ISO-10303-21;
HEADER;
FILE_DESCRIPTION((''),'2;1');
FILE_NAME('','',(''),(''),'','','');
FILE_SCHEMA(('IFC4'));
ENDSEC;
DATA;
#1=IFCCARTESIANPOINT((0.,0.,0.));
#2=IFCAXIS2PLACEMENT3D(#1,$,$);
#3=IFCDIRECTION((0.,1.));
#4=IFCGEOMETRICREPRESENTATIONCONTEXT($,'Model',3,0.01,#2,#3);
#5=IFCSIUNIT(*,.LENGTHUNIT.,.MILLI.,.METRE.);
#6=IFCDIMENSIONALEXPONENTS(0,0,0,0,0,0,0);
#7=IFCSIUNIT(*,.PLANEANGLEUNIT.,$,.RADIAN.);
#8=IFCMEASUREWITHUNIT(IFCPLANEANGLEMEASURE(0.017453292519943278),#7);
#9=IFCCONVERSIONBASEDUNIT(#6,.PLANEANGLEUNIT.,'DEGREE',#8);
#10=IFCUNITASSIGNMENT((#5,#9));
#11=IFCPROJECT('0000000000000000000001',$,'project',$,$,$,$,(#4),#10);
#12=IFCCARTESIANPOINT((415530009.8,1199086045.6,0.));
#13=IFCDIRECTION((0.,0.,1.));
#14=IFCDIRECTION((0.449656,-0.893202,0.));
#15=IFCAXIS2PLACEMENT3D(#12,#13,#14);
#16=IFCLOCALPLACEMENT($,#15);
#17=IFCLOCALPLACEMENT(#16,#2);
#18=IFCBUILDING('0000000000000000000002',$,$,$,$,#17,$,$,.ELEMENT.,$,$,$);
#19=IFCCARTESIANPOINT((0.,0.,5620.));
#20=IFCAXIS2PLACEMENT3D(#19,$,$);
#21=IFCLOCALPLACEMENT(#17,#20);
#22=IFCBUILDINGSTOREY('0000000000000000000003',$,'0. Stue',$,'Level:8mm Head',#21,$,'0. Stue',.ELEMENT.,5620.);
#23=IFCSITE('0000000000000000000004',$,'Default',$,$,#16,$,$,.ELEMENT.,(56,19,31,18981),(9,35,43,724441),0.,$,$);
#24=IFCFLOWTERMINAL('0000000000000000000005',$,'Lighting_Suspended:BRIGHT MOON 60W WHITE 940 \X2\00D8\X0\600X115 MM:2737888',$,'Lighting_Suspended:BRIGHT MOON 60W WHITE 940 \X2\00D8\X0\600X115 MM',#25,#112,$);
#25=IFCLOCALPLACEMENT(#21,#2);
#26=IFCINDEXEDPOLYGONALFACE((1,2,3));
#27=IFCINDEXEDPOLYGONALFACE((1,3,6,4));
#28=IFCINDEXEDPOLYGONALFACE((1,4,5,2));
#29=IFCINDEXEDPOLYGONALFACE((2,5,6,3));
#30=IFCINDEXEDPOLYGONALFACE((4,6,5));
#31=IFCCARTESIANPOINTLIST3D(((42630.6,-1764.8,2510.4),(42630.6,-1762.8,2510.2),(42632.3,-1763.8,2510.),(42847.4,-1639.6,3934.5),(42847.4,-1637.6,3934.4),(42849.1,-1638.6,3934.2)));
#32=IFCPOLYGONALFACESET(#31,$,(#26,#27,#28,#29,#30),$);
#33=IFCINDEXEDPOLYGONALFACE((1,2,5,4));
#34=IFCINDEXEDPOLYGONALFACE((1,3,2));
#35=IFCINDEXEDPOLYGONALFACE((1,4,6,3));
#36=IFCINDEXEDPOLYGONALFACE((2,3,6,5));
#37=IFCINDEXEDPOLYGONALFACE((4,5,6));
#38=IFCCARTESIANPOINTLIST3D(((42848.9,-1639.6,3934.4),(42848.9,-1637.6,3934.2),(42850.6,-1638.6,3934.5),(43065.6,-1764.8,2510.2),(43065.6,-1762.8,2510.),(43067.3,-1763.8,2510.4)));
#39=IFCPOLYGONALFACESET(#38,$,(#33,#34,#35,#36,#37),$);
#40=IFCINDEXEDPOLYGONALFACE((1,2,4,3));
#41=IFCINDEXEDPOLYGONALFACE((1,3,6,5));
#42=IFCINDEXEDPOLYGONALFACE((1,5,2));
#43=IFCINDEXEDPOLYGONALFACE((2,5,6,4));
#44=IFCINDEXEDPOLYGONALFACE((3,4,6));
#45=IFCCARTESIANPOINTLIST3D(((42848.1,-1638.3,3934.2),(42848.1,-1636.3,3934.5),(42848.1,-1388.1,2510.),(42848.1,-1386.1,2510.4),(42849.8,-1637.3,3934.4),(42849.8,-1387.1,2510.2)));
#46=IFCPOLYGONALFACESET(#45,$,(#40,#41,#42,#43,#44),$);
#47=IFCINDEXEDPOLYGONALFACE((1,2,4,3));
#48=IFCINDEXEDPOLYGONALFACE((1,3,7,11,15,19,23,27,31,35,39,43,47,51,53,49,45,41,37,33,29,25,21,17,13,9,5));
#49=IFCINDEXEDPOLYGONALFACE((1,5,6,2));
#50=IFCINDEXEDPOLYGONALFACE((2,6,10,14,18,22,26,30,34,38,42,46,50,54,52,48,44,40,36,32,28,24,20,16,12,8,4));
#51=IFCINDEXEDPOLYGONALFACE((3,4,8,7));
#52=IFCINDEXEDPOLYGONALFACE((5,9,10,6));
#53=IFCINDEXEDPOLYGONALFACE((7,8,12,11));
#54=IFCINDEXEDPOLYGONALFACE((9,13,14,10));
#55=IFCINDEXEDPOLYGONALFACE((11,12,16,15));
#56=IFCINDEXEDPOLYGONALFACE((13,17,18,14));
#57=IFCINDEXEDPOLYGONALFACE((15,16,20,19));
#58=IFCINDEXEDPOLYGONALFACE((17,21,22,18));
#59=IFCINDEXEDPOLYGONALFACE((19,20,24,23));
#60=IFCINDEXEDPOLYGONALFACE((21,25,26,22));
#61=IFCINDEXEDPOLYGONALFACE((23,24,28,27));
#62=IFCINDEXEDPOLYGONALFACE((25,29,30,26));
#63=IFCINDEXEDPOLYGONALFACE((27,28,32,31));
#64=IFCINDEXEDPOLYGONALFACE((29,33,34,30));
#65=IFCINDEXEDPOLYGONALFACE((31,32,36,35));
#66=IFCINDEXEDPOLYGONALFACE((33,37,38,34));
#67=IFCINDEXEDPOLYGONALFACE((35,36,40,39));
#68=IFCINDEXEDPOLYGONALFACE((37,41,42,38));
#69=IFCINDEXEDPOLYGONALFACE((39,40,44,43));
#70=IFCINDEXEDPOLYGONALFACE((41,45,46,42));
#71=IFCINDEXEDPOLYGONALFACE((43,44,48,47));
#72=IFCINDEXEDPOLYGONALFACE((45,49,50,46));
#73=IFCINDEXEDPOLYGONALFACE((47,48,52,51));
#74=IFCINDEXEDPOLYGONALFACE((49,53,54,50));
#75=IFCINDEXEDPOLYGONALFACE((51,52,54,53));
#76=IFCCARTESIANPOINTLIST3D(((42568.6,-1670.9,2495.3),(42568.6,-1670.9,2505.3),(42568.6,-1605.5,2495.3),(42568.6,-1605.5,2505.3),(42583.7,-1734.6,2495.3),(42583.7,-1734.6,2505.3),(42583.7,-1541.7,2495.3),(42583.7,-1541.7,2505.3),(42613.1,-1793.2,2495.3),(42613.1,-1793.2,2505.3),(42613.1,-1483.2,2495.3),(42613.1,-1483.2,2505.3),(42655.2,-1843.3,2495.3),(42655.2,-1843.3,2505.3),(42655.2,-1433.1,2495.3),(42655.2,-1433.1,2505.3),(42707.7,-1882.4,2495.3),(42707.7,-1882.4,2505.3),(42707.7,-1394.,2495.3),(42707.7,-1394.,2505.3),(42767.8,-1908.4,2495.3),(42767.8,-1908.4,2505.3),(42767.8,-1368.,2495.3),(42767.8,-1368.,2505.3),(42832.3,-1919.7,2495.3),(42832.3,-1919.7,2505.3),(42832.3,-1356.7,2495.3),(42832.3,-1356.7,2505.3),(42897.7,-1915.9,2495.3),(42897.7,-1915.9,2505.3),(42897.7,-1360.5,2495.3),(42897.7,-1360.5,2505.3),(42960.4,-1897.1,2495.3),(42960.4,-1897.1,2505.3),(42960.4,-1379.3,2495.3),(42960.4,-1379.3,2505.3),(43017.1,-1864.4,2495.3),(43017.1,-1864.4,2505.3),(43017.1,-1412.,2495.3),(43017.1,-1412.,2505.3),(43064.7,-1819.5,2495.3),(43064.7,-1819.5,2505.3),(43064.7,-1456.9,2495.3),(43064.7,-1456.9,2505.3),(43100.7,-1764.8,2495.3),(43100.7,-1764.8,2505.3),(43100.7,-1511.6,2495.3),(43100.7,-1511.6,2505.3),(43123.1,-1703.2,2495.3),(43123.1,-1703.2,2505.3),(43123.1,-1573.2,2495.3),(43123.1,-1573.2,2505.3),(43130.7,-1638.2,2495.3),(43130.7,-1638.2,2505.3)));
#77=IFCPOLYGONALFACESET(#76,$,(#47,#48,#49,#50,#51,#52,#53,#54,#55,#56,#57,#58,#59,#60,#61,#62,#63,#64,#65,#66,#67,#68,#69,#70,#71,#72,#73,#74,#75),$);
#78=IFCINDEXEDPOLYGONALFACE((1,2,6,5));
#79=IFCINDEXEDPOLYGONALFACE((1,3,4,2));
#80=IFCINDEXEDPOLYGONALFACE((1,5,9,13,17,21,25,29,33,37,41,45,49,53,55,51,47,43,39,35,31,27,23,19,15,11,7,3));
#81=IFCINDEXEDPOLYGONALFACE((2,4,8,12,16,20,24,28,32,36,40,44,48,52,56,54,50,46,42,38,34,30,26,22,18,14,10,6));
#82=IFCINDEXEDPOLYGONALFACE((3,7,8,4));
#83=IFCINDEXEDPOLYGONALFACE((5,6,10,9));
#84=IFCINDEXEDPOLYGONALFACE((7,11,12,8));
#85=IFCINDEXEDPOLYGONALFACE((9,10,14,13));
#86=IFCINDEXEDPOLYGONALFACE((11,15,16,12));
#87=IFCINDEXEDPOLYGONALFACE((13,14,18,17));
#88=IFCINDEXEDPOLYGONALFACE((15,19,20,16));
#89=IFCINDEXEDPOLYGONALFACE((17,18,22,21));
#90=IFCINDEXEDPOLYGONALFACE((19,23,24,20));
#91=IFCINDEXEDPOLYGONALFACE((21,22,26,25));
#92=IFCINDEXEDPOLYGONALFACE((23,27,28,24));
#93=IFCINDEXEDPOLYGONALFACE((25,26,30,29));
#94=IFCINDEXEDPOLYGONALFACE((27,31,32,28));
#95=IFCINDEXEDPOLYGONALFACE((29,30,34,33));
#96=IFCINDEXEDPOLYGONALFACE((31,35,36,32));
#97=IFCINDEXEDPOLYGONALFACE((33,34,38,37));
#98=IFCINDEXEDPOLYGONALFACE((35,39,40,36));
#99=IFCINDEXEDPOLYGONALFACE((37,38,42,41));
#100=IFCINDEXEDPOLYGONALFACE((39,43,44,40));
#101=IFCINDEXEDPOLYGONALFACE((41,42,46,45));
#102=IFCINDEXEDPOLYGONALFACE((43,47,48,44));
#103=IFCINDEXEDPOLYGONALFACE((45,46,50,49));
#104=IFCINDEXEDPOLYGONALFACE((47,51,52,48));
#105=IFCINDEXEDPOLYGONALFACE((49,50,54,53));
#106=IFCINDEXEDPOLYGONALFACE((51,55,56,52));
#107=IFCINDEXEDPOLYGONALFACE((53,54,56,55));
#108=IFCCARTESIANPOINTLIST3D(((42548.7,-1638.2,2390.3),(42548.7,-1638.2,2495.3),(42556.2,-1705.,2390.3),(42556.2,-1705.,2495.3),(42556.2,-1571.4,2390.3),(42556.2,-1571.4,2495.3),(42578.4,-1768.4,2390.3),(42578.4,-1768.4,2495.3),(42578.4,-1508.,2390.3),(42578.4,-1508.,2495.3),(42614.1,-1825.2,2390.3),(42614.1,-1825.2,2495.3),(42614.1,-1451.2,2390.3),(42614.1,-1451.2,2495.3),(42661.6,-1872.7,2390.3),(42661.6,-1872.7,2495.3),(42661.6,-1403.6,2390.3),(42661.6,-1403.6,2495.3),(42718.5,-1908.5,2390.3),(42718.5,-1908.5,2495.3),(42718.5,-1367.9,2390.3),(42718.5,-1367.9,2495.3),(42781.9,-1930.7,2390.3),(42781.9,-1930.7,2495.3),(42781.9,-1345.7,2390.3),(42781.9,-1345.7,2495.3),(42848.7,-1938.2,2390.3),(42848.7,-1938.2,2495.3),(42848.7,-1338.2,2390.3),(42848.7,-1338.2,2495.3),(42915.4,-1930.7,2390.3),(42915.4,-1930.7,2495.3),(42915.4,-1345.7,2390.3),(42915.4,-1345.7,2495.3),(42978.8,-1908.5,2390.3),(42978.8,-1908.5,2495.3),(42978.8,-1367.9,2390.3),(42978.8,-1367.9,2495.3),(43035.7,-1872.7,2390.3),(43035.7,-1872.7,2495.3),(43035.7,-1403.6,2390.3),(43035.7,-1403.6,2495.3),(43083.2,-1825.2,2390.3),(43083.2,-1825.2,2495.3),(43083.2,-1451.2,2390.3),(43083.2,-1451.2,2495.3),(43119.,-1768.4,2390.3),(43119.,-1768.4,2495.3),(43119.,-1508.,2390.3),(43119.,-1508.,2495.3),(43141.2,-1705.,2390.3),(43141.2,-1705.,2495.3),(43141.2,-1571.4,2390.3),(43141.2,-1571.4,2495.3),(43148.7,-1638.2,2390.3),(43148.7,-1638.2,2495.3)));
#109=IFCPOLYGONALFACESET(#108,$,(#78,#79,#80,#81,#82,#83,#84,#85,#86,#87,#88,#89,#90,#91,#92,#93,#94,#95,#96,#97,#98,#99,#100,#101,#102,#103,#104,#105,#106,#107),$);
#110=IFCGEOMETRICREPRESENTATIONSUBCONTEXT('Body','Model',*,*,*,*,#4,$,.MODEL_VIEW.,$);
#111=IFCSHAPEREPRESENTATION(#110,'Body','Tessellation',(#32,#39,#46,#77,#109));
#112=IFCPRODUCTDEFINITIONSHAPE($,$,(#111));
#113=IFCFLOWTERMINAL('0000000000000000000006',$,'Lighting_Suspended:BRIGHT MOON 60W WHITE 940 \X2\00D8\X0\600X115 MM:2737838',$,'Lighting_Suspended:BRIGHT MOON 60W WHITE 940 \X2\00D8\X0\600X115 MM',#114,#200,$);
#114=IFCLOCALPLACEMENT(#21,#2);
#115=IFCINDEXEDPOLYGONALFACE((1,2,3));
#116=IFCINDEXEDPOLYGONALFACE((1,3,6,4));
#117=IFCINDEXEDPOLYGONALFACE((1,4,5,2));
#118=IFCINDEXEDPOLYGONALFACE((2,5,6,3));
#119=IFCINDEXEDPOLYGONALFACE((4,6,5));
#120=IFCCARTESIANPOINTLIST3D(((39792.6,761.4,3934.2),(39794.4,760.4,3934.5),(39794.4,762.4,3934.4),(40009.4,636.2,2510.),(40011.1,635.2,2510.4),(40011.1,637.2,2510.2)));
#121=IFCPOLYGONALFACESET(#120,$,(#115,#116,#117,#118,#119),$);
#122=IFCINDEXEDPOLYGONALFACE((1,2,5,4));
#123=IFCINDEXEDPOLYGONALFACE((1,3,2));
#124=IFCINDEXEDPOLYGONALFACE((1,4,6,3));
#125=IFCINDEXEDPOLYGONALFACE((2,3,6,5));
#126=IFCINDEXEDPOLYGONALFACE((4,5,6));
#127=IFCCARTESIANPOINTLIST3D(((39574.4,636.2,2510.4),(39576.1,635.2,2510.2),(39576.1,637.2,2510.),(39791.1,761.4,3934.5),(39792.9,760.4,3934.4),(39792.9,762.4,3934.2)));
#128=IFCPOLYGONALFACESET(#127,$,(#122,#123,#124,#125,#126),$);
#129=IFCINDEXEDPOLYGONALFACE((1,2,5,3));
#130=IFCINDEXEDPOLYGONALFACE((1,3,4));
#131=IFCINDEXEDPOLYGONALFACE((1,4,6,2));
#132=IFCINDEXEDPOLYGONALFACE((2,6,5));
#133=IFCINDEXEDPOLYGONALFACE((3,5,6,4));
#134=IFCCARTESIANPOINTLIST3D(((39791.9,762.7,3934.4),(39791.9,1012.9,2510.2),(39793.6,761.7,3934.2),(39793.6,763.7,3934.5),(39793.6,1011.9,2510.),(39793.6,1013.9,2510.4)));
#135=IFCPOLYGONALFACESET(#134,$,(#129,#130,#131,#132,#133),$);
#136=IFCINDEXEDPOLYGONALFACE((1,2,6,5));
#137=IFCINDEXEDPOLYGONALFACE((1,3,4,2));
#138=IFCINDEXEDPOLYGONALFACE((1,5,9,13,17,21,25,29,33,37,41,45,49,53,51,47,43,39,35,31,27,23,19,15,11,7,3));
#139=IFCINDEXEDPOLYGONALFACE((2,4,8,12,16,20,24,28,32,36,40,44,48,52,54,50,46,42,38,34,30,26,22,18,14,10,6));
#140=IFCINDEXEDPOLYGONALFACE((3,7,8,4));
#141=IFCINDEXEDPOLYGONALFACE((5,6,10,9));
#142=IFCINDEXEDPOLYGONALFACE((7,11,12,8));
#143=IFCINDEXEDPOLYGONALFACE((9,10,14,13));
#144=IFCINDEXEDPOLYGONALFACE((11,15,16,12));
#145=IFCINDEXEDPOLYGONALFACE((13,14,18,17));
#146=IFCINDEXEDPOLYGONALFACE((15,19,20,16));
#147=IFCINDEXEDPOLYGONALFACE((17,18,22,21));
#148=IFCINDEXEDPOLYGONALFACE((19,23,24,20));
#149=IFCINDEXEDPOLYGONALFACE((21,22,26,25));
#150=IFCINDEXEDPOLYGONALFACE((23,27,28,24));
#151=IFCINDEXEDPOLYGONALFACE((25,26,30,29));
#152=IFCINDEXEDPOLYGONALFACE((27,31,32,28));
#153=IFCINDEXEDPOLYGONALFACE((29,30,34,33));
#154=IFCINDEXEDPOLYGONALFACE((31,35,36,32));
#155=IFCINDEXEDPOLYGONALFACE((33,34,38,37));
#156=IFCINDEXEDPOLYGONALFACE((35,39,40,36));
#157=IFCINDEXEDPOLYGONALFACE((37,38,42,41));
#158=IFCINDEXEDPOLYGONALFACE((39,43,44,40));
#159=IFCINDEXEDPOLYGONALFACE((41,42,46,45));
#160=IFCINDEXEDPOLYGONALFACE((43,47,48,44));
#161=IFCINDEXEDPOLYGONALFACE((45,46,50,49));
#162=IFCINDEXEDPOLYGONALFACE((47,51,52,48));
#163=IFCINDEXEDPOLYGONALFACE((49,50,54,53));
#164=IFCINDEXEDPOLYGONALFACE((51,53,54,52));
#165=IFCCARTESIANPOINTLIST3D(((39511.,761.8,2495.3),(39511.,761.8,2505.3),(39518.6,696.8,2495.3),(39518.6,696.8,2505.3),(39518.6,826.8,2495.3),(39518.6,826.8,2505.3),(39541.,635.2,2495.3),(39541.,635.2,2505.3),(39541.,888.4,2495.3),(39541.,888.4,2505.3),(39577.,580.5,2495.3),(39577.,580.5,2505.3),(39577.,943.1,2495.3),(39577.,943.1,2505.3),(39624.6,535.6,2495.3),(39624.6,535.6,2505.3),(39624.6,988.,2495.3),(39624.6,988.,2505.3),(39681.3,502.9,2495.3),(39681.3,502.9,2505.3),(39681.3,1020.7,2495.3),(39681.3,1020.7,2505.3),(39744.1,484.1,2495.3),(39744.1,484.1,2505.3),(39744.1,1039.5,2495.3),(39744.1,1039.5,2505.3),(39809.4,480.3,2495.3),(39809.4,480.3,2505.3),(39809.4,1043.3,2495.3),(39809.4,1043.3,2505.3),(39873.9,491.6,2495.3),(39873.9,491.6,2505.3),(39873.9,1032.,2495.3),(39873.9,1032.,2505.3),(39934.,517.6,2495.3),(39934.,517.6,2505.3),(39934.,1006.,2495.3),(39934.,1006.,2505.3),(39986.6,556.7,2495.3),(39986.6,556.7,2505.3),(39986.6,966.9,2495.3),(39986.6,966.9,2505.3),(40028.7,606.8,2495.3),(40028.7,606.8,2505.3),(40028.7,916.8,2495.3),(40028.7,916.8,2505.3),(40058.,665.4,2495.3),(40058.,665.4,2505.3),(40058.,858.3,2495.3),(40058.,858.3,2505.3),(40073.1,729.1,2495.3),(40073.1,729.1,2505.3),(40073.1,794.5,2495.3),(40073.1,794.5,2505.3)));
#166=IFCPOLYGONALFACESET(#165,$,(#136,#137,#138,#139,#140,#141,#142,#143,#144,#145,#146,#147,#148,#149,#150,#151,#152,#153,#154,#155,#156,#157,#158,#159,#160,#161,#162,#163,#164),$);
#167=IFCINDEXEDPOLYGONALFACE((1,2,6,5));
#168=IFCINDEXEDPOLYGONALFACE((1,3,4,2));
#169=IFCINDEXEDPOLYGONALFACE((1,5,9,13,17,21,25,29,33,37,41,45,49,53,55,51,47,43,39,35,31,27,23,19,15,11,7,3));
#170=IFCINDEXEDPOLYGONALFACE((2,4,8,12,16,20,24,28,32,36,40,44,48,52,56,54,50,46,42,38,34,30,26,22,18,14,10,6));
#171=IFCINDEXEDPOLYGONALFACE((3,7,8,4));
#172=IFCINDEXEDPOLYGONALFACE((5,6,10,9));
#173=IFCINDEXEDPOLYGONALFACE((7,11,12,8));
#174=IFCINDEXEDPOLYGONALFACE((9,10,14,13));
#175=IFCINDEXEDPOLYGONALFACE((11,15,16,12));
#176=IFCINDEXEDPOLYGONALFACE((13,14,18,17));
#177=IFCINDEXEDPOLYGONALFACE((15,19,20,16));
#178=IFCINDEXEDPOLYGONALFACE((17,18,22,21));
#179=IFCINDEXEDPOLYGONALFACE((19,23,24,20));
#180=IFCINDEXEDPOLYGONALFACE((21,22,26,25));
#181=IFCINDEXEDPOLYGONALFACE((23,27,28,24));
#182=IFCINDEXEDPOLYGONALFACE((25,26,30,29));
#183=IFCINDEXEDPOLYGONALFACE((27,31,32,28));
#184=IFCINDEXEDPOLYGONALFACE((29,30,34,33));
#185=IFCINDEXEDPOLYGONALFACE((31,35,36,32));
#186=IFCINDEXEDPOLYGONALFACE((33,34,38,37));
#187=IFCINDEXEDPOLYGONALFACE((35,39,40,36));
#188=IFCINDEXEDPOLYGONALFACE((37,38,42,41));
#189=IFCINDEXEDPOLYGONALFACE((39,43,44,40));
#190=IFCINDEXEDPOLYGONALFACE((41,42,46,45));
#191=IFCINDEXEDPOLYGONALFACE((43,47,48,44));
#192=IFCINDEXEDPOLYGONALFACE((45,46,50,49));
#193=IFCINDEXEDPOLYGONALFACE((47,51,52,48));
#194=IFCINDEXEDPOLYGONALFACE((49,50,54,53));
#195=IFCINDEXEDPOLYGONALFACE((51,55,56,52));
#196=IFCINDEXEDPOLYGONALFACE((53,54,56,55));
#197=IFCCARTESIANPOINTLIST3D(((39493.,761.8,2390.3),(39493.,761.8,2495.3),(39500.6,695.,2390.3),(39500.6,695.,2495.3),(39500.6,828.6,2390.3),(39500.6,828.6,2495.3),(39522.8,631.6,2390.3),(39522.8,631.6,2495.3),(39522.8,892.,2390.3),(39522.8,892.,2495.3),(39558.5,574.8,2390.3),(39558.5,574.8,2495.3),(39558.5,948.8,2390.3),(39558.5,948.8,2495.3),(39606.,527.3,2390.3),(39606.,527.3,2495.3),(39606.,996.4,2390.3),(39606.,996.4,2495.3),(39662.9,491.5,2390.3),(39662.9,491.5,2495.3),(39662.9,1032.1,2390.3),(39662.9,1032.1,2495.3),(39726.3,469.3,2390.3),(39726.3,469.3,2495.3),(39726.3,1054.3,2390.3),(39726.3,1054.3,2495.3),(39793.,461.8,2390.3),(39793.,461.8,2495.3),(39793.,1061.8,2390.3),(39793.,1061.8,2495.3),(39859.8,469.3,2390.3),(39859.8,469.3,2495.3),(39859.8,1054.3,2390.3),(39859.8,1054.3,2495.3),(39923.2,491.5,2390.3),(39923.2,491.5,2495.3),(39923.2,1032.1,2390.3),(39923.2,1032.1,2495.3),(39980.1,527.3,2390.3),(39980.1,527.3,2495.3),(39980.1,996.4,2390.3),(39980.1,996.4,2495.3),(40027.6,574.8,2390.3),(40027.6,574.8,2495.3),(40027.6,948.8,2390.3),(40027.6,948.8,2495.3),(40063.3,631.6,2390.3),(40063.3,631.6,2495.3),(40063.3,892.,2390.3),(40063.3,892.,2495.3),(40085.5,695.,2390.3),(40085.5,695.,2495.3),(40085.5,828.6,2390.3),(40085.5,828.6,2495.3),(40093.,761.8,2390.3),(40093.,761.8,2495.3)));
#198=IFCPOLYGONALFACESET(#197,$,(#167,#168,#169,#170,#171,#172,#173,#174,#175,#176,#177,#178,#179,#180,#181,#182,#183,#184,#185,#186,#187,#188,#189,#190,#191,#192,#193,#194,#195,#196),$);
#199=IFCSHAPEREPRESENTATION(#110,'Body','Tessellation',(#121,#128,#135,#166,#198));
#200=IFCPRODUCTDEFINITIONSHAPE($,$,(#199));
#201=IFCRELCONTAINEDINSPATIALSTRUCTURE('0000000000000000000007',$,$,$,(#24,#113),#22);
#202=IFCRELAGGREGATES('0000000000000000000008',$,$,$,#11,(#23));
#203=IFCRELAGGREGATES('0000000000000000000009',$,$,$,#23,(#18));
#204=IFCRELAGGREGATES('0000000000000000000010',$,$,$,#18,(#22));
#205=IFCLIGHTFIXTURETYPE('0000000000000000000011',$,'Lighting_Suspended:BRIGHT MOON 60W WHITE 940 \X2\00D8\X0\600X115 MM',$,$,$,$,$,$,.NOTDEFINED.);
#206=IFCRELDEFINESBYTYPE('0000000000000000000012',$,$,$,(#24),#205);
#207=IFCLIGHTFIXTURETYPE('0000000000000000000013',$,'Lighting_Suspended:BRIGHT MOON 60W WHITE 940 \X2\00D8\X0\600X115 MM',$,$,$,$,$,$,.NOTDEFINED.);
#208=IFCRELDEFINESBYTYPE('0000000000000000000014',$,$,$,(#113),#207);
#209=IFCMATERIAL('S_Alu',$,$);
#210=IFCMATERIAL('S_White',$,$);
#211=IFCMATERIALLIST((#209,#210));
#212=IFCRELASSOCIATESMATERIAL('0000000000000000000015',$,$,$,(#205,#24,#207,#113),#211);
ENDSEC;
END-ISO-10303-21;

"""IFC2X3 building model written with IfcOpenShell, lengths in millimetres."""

from ifc_helpers import new_model, entity, si_unit, converted_unit, direction, frame, frame_2d, origin, place, context, subcontext, project, spatial, polyline, circle, outline, extrude, source, transform, mapped, material, material_list, type_object, type_shapes, element, save


model = new_model("IFC2X3")

# Units and contexts
model_context = context("Model", 3, precision=0.01, world=origin(), true_north=direction((0.0, 1.0)))
body_context = subcontext(model_context, "Body", "Model", "MODEL_VIEW")
ifc_project = project(units=[si_unit("LENGTHUNIT", "METRE", prefix="MILLI"), converted_unit("PLANEANGLEUNIT", "DEGREE", entity("IfcPlaneAngleMeasure", 0.017453292519943278), si_unit("PLANEANGLEUNIT", "RADIAN"), dimensions=[0, 0, 0, 0, 0, 0, 0])], contexts=[model_context])

# Site, building, storey
site_placement = place(None, frame((415530009.8, 1199086045.6, 0.0), z_axis=(0.0, 0.0, 1.0), x_axis=(0.449656, -0.893202, 0.0)))
site = spatial("IfcSite", under=ifc_project, at=site_placement, Name="Default", CompositionType="ELEMENT", RefLatitude=(56, 19, 31, 18981), RefLongitude=(9, 35, 43, 724441), RefElevation=0.0)
building_placement = place(site_placement, origin())
building = spatial("IfcBuilding", under=site, at=building_placement, CompositionType="ELEMENT")
storey_placement = place(building_placement, frame((0.0, 0.0, 5620.0)))
storey = spatial("IfcBuildingStorey", under=building, at=storey_placement, Name="0. Stue", ObjectType="Level:8mm Head", LongName="0. Stue", CompositionType="ELEMENT", Elevation=5620.0)

# Flow terminals
ifc_material_1 = material(Name="S_White")
ifc_material_2 = material(Name="S_Alu")
ifc_material_list = material_list([ifc_material_2, ifc_material_1])
light_fixture_type_1 = type_object("IfcLightFixtureType", Name="Lighting_Suspended:BRIGHT MOON 60W WHITE 940 Ø600X115 MM", PredefinedType="NOTDEFINED", material=ifc_material_list)
shared_shape_1 = source(origin(), body_context, "Body", "SweptSolid", [
    extrude(outline(polyline([(-1.0, -0.6), (1.0, -0.6), (0.0, 1.2), (-1.0, -0.6)])), frame((-217.5, -125.6, -1429.1), z_axis=(0.149892, 0.08654, 0.984908), x_axis=(-0.85949, 0.503773, 0.08654)), (0.0, 0.0, 1.0), 1446.0),
    extrude(outline(polyline([(-1.0, -0.6), (1.0, -0.6), (0.0, 1.2), (-1.0, -0.6)])), frame((217.5, -125.6, -1429.1), z_axis=(-0.149892, 0.08654, 0.984908), x_axis=(-0.006535, -0.996227, 0.08654)), (0.0, 0.0, 1.0), 1446.0),
    extrude(outline(polyline([(-1.0, -0.6), (1.0, -0.6), (0.0, 1.2), (-1.0, -0.6)])), frame((0.0, 251.1, -1429.1), z_axis=(0.0, -0.17308, 0.984908), x_axis=(0.866025, 0.492454, 0.08654)), (0.0, 0.0, 1.0), 1446.0),
    extrude(circle(Radius=282.0, at=frame_2d((0.0, 0.0), x_axis=(1.0, 0.0))), frame((0.0, 0.0, -1444.0)), (0.0, 0.0, 1.0), 10.0),
    extrude(circle(Radius=300.0, at=frame_2d((0.0, 0.0), x_axis=(1.0, 0.0))), frame((0.0, 0.0, -1549.0)), (0.0, 0.0, 1.0), 105.0),
])
type_shapes(light_fixture_type_1, [shared_shape_1])
for number, where, name in (
    (1, (42848.7, -1638.2, 3939.3), "Lighting_Suspended:BRIGHT MOON 60W WHITE 940 Ø600X115 MM:2737888"),
):
    element("IfcFlowTerminal", number, at=place(storey_placement, frame(where)), inside=storey, type_object=light_fixture_type_1, material=ifc_material_list, Name=name, ObjectType="Lighting_Suspended:BRIGHT MOON 60W WHITE 940 Ø600X115 MM", context=body_context, shape_type="MappedRepresentation", body=[
        mapped(shared_shape_1, transform((0.0, 0.0, 0.0), scale=1.0)),
    ])
light_fixture_type_2 = type_object("IfcLightFixtureType", Name="Lighting_Suspended:BRIGHT MOON 60W WHITE 940 Ø600X115 MM", PredefinedType="NOTDEFINED", material=ifc_material_list)
shared_shape_2 = source(origin(), body_context, "Body", "SweptSolid", [
    extrude(outline(polyline([(-1.0, -0.6), (1.0, -0.6), (0.0, 1.2), (-1.0, -0.6)])), frame((-217.5, 125.6, -1429.1), z_axis=(0.149892, -0.08654, 0.984908), x_axis=(-0.852955, 0.492454, 0.17308)), (0.0, 0.0, 1.0), 1446.0),
    extrude(outline(polyline([(-1.0, -0.6), (1.0, -0.6), (0.0, 1.2), (-1.0, -0.6)])), frame((217.5, 125.6, -1429.1), z_axis=(-0.149892, -0.08654, 0.984908), x_axis=(0.852955, 0.492454, 0.17308)), (0.0, 0.0, 1.0), 1446.0),
    extrude(outline(polyline([(-1.0, -0.6), (1.0, -0.6), (0.0, 1.2), (-1.0, -0.6)])), frame((0.0, -251.1, -1429.1), z_axis=(0.0, 0.17308, 0.984908), x_axis=(0.0, -0.984908, 0.17308)), (0.0, 0.0, 1.0), 1446.0),
    extrude(circle(Radius=282.0, at=frame_2d((0.0, 0.0), x_axis=(1.0, 0.0))), frame((0.0, 0.0, -1444.0)), (0.0, 0.0, 1.0), 10.0),
    extrude(circle(Radius=300.0, at=frame_2d((0.0, 0.0), x_axis=(1.0, 0.0))), frame((0.0, 0.0, -1549.0)), (0.0, 0.0, 1.0), 105.0),
])
type_shapes(light_fixture_type_2, [shared_shape_2])
for number, where, z_axis, x_axis, name in (
    (2, (39793.0, 761.8, 3939.3), (0.0, 0.0, 1.0), (-1.0, 0.0, 0.0), "Lighting_Suspended:BRIGHT MOON 60W WHITE 940 Ø600X115 MM:2737838"),
):
    element("IfcFlowTerminal", number, at=place(storey_placement, frame(where, z_axis=z_axis, x_axis=x_axis)), inside=storey, type_object=light_fixture_type_2, material=ifc_material_list, Name=name, ObjectType="Lighting_Suspended:BRIGHT MOON 60W WHITE 940 Ø600X115 MM", context=body_context, shape_type="MappedRepresentation", body=[
        mapped(shared_shape_2, transform((0.0, 0.0, 0.0), scale=1.0)),
    ])

save(model, "model.ifc")
